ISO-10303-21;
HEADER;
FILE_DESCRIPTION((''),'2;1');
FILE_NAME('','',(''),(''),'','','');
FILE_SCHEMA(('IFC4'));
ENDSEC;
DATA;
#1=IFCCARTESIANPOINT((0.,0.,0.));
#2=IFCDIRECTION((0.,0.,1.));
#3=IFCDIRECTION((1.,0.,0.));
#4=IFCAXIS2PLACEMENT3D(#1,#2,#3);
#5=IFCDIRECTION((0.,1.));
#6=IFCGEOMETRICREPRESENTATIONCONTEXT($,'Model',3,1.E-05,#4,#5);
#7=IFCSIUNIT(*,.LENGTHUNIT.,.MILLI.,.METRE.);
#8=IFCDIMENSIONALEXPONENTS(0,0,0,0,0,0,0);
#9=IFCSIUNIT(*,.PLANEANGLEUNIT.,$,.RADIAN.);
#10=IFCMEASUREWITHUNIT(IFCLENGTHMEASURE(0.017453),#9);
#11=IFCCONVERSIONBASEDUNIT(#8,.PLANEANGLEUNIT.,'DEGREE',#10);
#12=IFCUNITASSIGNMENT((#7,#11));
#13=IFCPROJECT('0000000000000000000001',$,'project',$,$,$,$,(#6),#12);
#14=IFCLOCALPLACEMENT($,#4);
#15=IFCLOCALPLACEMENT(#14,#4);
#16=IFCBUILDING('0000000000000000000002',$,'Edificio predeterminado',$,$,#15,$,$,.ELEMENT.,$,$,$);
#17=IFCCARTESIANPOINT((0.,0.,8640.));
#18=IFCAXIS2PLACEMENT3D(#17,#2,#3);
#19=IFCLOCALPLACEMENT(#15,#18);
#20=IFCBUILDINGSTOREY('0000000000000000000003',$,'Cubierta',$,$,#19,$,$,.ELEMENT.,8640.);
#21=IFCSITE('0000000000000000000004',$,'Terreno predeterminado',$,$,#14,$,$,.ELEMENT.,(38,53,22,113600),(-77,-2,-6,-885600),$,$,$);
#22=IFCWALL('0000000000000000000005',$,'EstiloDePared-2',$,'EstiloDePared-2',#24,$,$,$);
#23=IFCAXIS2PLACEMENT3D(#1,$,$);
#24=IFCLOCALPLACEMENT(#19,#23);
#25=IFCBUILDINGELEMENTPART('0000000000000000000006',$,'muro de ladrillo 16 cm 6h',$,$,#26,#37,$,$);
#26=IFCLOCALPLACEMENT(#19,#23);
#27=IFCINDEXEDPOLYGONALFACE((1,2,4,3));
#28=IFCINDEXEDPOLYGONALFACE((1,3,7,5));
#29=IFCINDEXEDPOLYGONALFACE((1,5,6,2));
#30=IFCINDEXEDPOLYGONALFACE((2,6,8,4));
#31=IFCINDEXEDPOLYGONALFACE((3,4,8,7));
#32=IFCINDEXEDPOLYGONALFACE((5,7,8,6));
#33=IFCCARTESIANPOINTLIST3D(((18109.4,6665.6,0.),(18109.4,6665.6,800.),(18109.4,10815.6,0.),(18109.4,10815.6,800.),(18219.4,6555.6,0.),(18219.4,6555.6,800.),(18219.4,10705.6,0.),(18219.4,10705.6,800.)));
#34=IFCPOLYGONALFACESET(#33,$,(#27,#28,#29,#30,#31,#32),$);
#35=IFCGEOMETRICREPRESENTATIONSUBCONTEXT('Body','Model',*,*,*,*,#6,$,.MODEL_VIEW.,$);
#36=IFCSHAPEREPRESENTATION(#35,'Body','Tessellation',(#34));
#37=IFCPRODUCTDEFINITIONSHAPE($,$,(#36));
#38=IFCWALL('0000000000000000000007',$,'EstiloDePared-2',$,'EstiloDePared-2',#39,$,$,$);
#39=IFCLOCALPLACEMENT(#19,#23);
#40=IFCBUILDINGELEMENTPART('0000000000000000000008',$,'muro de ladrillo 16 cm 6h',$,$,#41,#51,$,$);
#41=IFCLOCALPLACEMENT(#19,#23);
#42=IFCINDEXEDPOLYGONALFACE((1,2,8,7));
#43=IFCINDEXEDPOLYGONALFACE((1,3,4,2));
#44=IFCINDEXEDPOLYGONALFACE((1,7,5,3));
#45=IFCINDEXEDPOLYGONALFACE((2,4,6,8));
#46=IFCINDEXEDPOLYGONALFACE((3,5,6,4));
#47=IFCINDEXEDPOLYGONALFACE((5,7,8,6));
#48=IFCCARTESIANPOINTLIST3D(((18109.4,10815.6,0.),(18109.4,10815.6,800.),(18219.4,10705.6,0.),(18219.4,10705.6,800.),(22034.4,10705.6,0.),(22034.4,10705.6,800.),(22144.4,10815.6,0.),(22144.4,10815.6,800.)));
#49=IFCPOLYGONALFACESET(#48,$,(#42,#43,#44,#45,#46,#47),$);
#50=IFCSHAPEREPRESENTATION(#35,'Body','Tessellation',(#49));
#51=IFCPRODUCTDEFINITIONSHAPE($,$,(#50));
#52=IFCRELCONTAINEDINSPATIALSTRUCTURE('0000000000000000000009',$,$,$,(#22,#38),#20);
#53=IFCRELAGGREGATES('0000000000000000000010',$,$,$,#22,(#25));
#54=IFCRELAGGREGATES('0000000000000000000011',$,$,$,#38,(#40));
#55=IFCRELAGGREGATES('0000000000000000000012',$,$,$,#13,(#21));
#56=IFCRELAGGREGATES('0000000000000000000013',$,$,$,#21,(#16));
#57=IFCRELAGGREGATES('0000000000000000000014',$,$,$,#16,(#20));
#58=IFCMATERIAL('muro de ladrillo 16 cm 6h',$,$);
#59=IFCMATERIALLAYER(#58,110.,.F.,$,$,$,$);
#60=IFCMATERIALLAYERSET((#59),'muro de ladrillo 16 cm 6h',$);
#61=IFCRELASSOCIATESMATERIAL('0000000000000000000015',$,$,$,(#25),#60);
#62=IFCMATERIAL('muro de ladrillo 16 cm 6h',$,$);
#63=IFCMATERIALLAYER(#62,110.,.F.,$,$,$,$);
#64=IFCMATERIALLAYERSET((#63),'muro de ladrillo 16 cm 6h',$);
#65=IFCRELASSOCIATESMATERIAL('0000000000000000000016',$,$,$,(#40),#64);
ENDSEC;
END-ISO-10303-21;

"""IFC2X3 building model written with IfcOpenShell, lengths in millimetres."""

from ifc_helpers import new_model, entity, si_unit, converted_unit, direction, frame, origin_with_axes, place, context, subcontext, project, spatial, polyline, outline, extrude, material, layer, layer_set, layer_usage, element, aggregate, save


model = new_model("IFC2X3")

# Units and contexts
model_context = context("Model", 3, precision=1e-05, world=origin_with_axes(), true_north=direction((0.0, 1.0)))
body_context = subcontext(model_context, "Body", "Model", "MODEL_VIEW")
ifc_project = project(units=[si_unit("LENGTHUNIT", "METRE", prefix="MILLI"), converted_unit("PLANEANGLEUNIT", "DEGREE", entity("IfcLengthMeasure", 0.017453), si_unit("PLANEANGLEUNIT", "RADIAN"), dimensions=[0, 0, 0, 0, 0, 0, 0])], contexts=[model_context])

# Site, building, storey
site_placement = place(None, origin_with_axes())
site = spatial("IfcSite", under=ifc_project, at=site_placement, Name="Terreno predeterminado", CompositionType="ELEMENT", RefLatitude=(38, 53, 22, 113600), RefLongitude=(-77, -2, -6, -885600))
building_placement = place(site_placement, origin_with_axes())
building = spatial("IfcBuilding", under=site, at=building_placement, Name="Edificio predeterminado", CompositionType="ELEMENT")
storey_placement = place(building_placement, frame((0.0, 0.0, 8640.0), z_axis=(0.0, 0.0, 1.0), x_axis=(1.0, 0.0, 0.0)))
storey = spatial("IfcBuildingStorey", under=building, at=storey_placement, Name="Cubierta", CompositionType="ELEMENT", Elevation=8640.0)

# Walls, building element parts
wall_1_placement = place(storey_placement, frame((18164.4, 6610.6, 0.0), z_axis=(0.0, 0.0, 1.0), x_axis=(0.0, 1.0, 0.0)))
wall_1 = element("IfcWall", 1, at=wall_1_placement, inside=storey, Name="EstiloDePared-2", ObjectType="EstiloDePared-2")
ifc_material_1 = material(Name="muro de ladrillo 16 cm 6h")
ifc_layer_1 = layer(ifc_material_1, 110.0, ventilated=False)
ifc_layer_set_1 = layer_set([ifc_layer_1], Name="muro de ladrillo 16 cm 6h")
ifc_layer_usage_1 = layer_usage(ifc_layer_set_1, "AXIS2", "NEGATIVE", -55.0)
building_element_part_1_placement = place(wall_1_placement, origin_with_axes())
building_element_part_1 = element("IfcBuildingElementPart", 2, at=building_element_part_1_placement, material=ifc_layer_usage_1, Name="muro de ladrillo 16 cm 6h", context=body_context, shape_type="SweptSolid", body=[
    extrude(outline(polyline([(4205.0, 55.0), (4095.0, -55.0), (-55.0, -55.0), (55.0, 55.0), (4205.0, 55.0)])), origin_with_axes(), (0.0, 0.0, 1.0), 800.0),
])
aggregate(wall_1, [building_element_part_1])
wall_2_placement = place(storey_placement, frame((18164.4, 10760.6, 0.0), z_axis=(0.0, 0.0, 1.0), x_axis=(1.0, 0.0, 0.0)))
wall_2 = element("IfcWall", 3, at=wall_2_placement, inside=storey, Name="EstiloDePared-2", ObjectType="EstiloDePared-2")
ifc_material_2 = material(Name="muro de ladrillo 16 cm 6h")
ifc_layer_2 = layer(ifc_material_2, 110.0, ventilated=False)
ifc_layer_set_2 = layer_set([ifc_layer_2], Name="muro de ladrillo 16 cm 6h")
ifc_layer_usage_2 = layer_usage(ifc_layer_set_2, "AXIS2", "NEGATIVE", -55.0)
building_element_part_2_placement = place(wall_2_placement, origin_with_axes())
building_element_part_2 = element("IfcBuildingElementPart", 4, at=building_element_part_2_placement, material=ifc_layer_usage_2, Name="muro de ladrillo 16 cm 6h", context=body_context, shape_type="SweptSolid", body=[
    extrude(outline(polyline([(3980.0, 55.0), (3870.0, -55.0), (55.0, -55.0), (-55.0, 55.0), (3980.0, 55.0)])), origin_with_axes(), (0.0, 0.0, 1.0), 800.0),
])
aggregate(wall_2, [building_element_part_2])

save(model, "model.ifc")
